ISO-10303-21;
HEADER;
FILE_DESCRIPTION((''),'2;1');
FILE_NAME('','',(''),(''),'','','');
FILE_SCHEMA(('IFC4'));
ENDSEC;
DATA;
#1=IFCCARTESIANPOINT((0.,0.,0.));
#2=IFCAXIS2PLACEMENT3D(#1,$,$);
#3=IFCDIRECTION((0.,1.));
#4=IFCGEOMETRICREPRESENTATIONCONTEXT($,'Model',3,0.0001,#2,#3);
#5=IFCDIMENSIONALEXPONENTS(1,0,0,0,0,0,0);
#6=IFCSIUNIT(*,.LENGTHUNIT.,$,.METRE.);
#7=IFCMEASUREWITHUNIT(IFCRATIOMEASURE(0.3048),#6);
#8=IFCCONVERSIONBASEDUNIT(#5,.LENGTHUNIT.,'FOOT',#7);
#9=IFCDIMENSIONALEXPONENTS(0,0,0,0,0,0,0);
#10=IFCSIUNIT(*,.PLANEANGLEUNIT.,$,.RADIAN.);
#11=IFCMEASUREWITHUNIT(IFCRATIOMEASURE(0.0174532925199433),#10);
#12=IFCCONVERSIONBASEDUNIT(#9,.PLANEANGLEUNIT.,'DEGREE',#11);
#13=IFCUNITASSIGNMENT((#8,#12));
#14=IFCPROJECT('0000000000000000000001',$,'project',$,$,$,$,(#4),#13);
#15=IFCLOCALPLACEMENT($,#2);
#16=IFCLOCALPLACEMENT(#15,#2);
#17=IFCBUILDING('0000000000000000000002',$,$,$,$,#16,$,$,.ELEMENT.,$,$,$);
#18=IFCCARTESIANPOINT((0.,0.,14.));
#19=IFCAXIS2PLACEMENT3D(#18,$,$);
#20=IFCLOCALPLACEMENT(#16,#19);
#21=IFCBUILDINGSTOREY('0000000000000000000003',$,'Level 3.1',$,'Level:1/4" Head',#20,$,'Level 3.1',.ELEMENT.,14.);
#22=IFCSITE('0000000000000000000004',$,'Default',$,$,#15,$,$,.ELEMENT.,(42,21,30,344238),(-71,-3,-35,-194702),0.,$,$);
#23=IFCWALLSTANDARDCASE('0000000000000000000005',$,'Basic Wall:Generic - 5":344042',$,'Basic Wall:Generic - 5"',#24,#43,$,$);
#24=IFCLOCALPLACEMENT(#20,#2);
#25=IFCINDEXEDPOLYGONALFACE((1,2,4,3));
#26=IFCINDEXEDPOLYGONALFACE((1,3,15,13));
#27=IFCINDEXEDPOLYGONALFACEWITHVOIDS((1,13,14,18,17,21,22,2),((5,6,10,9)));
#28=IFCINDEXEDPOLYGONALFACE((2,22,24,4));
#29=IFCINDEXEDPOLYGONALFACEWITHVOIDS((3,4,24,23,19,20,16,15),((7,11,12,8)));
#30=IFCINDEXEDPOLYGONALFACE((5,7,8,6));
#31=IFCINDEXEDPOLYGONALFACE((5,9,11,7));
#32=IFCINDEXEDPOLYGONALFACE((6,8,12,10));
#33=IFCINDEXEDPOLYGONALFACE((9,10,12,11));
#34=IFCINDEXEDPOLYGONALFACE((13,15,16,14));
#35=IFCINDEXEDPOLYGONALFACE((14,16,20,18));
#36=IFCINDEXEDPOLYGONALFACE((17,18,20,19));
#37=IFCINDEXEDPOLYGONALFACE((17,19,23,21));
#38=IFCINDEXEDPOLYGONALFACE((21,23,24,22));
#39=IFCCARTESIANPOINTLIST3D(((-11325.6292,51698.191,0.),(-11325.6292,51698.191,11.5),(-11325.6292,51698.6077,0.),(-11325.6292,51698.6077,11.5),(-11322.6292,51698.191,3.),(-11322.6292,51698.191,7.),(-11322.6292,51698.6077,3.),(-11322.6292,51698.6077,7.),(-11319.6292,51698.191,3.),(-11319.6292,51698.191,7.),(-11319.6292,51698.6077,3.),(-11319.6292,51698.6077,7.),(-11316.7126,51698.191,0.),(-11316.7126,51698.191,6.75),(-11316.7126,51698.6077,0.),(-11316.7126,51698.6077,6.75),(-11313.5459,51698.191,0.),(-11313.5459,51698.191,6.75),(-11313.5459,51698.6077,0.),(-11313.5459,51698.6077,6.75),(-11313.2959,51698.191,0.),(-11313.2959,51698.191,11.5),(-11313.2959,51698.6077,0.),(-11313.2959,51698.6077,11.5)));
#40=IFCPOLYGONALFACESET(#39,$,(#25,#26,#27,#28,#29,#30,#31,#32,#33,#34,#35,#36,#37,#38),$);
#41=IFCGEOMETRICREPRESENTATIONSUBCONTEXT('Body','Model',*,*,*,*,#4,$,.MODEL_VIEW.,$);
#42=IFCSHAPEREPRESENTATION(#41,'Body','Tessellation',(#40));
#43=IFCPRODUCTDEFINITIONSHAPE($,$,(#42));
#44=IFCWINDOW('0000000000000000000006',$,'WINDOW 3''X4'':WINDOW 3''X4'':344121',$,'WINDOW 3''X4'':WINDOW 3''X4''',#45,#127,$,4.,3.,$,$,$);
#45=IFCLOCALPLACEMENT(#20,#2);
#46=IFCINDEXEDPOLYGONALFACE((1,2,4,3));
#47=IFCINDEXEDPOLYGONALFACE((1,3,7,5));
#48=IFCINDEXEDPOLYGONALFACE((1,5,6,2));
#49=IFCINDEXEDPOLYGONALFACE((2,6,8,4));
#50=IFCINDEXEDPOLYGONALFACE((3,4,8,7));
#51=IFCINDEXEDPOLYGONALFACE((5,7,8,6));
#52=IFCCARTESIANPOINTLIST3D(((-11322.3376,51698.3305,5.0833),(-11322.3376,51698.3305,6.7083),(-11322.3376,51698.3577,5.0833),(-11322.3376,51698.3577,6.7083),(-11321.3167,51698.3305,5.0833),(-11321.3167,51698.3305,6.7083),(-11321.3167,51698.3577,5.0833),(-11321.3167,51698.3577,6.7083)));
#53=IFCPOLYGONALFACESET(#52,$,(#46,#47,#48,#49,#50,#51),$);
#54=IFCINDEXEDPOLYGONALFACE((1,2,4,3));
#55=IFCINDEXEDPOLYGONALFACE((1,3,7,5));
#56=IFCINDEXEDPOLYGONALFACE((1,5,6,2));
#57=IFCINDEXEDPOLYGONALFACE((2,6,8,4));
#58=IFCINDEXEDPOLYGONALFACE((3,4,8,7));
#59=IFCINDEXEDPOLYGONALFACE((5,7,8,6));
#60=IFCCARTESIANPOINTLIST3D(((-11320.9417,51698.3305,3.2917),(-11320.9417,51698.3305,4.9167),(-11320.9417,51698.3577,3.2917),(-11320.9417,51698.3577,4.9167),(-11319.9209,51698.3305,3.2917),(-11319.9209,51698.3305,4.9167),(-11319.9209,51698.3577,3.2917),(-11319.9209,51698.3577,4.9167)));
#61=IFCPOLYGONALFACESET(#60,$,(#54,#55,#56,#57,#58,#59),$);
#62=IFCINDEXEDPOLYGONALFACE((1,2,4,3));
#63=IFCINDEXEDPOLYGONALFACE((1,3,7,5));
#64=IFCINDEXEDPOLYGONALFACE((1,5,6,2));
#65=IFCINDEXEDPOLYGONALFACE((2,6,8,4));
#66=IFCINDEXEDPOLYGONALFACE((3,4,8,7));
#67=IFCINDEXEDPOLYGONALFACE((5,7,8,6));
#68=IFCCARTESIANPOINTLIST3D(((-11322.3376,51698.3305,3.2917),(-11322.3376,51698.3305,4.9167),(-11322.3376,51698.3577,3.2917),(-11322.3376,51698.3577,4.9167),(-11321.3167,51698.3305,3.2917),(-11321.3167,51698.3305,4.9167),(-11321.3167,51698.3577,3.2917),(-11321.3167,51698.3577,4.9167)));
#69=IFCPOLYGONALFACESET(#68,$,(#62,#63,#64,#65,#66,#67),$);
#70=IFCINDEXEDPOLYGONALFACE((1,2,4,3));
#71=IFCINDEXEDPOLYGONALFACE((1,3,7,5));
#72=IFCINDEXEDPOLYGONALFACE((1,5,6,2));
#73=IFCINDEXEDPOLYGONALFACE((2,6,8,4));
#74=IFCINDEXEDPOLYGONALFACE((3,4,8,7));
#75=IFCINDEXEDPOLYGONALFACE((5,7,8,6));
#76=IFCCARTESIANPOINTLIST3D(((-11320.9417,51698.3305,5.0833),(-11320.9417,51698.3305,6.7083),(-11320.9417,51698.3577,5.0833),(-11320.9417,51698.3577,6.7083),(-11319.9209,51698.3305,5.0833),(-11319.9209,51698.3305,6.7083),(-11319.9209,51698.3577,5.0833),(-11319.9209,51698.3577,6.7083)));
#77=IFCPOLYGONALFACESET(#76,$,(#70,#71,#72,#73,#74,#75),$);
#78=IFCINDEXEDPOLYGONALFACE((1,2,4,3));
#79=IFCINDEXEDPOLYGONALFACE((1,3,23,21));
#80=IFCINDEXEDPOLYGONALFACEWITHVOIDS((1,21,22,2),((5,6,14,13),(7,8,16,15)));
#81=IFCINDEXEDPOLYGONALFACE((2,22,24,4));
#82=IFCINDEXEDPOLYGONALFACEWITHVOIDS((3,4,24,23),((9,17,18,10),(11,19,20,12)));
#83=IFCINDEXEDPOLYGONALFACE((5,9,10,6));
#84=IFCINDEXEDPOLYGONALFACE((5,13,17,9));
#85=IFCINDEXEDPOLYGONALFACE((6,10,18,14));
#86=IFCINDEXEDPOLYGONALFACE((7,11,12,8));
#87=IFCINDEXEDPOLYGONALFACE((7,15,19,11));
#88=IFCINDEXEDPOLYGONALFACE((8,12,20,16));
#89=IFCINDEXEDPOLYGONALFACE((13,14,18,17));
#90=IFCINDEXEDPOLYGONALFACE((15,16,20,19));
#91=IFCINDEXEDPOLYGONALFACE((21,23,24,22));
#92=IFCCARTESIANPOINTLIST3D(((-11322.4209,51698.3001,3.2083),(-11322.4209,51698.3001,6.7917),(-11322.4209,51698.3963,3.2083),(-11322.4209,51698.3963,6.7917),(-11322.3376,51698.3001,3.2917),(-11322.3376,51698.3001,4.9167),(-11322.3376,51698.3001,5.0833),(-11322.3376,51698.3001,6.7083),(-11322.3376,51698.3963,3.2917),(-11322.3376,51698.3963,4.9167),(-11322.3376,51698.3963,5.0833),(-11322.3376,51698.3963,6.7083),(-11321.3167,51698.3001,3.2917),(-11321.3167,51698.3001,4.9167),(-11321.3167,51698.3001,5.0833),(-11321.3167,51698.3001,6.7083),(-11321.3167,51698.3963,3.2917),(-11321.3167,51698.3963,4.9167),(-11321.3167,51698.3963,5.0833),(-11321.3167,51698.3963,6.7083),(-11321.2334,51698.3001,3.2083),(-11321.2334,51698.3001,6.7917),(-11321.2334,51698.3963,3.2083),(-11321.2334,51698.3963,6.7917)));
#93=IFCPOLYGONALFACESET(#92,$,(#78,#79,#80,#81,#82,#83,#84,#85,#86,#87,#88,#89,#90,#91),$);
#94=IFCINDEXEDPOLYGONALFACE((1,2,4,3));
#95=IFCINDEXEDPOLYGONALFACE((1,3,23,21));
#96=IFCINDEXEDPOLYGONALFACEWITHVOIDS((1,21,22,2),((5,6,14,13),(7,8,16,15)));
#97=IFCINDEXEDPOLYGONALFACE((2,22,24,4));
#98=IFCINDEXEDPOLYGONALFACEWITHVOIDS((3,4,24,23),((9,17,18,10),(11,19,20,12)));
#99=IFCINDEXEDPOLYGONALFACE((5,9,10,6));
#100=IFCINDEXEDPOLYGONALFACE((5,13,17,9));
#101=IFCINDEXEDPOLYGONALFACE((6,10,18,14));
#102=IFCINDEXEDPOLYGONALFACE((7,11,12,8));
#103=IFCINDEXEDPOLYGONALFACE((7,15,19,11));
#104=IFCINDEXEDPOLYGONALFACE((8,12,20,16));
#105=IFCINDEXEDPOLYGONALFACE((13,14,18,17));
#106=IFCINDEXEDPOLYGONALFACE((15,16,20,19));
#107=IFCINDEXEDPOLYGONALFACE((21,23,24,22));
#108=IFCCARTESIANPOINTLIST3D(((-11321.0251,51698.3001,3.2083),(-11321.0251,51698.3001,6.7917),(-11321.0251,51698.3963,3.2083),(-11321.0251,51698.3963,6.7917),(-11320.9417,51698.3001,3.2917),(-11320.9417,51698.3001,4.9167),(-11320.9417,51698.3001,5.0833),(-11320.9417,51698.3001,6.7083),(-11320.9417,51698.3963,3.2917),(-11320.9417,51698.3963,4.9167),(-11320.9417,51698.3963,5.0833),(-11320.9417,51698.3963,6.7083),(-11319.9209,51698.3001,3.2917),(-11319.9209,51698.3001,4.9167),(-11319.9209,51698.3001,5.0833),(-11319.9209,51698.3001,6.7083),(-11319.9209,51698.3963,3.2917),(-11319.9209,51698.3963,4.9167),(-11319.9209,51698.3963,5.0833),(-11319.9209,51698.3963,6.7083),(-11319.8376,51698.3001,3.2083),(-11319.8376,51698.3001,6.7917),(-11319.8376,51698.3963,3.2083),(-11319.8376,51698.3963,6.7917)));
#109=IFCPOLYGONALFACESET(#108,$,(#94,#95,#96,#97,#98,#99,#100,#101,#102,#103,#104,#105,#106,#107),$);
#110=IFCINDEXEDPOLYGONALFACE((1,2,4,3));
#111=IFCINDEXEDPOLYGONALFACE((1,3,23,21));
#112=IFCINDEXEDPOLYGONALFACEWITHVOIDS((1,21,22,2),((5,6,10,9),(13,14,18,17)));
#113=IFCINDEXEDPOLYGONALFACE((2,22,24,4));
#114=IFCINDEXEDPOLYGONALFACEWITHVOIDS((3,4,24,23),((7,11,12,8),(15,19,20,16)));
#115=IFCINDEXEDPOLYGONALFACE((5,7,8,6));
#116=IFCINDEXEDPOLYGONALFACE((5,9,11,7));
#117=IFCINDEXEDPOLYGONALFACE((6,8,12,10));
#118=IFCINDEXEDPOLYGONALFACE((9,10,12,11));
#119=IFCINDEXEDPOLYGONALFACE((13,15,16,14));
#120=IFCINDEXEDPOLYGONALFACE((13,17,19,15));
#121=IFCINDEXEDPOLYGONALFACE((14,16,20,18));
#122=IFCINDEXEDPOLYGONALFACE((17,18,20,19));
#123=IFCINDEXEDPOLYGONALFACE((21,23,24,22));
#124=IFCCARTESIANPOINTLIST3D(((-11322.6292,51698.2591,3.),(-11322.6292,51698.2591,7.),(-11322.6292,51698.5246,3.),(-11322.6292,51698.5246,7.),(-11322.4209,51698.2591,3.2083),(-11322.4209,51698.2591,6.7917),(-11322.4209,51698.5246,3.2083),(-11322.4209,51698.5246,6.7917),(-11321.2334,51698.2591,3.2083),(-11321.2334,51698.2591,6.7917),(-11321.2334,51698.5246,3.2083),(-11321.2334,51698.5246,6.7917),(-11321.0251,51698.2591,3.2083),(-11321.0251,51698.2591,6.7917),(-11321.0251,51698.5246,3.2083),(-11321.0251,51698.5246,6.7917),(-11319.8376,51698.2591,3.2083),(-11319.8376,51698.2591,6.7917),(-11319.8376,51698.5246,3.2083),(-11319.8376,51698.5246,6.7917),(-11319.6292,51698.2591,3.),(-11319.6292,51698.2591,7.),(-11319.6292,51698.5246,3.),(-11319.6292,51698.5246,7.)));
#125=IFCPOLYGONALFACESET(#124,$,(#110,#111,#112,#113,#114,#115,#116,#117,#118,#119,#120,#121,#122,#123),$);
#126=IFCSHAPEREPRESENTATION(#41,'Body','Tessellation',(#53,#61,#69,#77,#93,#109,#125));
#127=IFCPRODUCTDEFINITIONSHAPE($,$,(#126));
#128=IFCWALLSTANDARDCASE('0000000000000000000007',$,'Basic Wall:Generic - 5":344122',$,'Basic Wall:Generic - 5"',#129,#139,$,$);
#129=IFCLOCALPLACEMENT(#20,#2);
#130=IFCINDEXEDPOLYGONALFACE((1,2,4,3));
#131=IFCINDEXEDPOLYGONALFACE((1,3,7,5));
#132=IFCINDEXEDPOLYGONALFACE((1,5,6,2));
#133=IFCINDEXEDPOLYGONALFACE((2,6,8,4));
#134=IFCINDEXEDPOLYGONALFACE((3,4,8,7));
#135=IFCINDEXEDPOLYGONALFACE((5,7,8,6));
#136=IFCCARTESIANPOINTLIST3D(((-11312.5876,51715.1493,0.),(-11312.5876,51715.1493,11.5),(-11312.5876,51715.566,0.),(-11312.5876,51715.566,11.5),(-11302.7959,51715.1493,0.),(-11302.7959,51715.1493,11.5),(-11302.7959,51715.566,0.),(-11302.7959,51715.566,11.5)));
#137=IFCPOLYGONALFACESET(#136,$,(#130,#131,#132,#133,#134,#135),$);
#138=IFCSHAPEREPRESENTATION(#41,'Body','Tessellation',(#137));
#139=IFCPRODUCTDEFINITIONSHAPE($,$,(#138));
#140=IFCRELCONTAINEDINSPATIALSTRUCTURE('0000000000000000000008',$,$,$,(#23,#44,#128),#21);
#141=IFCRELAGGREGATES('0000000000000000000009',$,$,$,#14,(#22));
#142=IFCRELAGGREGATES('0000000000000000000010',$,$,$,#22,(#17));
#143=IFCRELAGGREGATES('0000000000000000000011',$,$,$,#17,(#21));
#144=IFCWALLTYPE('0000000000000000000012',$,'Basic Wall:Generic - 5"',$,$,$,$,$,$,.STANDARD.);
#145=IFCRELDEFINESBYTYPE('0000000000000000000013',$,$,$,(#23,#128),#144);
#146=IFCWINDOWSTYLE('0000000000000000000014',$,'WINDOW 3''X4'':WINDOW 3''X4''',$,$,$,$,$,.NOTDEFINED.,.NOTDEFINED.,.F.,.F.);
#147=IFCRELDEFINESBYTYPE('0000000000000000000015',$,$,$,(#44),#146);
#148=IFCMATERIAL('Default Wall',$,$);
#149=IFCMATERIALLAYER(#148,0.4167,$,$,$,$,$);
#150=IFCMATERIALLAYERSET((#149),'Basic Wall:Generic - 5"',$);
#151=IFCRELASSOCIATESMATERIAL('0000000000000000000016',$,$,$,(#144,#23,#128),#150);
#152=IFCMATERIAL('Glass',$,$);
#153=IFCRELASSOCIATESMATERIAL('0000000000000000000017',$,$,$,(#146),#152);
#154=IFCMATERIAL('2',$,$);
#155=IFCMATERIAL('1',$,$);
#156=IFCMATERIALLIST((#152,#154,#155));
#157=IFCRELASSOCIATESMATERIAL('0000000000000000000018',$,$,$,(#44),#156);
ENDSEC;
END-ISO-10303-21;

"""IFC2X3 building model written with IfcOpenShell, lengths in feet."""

from ifc_helpers import new_model, entity, si_unit, converted_unit, direction, frame, frame_2d, origin, origin_2d_with_axis, place, context, subcontext, project, spatial, polyline, rectangle, outline, extrude, source, transform, mapped, material, material_list, layer, layer_set, layer_usage, type_object, type_shapes, element, fill, save


model = new_model("IFC2X3")

# Units and contexts
model_context = context("Model", 3, precision=0.0001, world=origin(), true_north=direction((0.0, 1.0)))
body_context = subcontext(model_context, "Body", "Model", "MODEL_VIEW")
ifc_project = project(units=[converted_unit("LENGTHUNIT", "FOOT", entity("IfcRatioMeasure", 0.3048), si_unit("LENGTHUNIT", "METRE"), dimensions=[1, 0, 0, 0, 0, 0, 0]), converted_unit("PLANEANGLEUNIT", "DEGREE", entity("IfcRatioMeasure", 0.0174532925199433), si_unit("PLANEANGLEUNIT", "RADIAN"), dimensions=[0, 0, 0, 0, 0, 0, 0])], contexts=[model_context])

# Site, building, storey
site_placement = place(None, origin())
site = spatial("IfcSite", under=ifc_project, at=site_placement, Name="Default", CompositionType="ELEMENT", RefLatitude=(42, 21, 30, 344238), RefLongitude=(-71, -3, -35, -194702), RefElevation=0.0)
building_placement = place(site_placement, origin())
building = spatial("IfcBuilding", under=site, at=building_placement, CompositionType="ELEMENT")
storey_placement = place(building_placement, frame((0.0, 0.0, 14.0)))
storey = spatial("IfcBuildingStorey", under=building, at=storey_placement, Name="Level 3.1", ObjectType="Level:1/4\" Head", LongName="Level 3.1", CompositionType="ELEMENT", Elevation=14.0)

# Shared definitions
ifc_material_1 = material(Name="Default Wall")

# Shared definitions
ifc_layer_1 = layer(ifc_material_1, 0.4167)
ifc_layer_set_1 = layer_set([ifc_layer_1], Name="Basic Wall:Generic - 5\"")
wall_type_1 = type_object("IfcWallType", Name="Basic Wall:Generic - 5\"", PredefinedType="STANDARD", material=ifc_layer_set_1)
ifc_material_2 = material(Name="Glass")
ifc_material_3 = material(Name="2")
ifc_material_4 = material(Name="1")

# Wall, openings, window
window_style_1 = type_object("IfcWindowStyle", Name="WINDOW 3'X4':WINDOW 3'X4'", ConstructionType="NOTDEFINED", OperationType="NOTDEFINED", ParameterTakesPrecedence=False, Sizeable=False, material=ifc_material_2)
shared_shape_1 = source(origin(), body_context, "Body", "SweptSolid", [
    extrude(rectangle(XDim=0.0272, YDim=1.0208, at=origin_2d_with_axis()), frame((2.1979, 0.2636, 2.0833), z_axis=(0.0, 0.0, 1.0), x_axis=(0.0, 1.0, 0.0)), (0.0, 0.0, 1.0), 1.625),
    extrude(rectangle(XDim=0.0272, YDim=1.0208, at=origin_2d_with_axis()), frame((0.8021, 0.2636, 0.2917), z_axis=(0.0, 0.0, 1.0), x_axis=(0.0, 1.0, 0.0)), (0.0, 0.0, 1.0), 1.625),
    extrude(rectangle(XDim=0.0272, YDim=1.0208, at=origin_2d_with_axis()), frame((2.1979, 0.2636, 0.2917), z_axis=(0.0, 0.0, 1.0), x_axis=(0.0, 1.0, 0.0)), (0.0, 0.0, 1.0), 1.625),
    extrude(rectangle(XDim=0.0272, YDim=1.0208, at=origin_2d_with_axis()), frame((0.8021, 0.2636, 2.0833), z_axis=(0.0, 0.0, 1.0), x_axis=(0.0, 1.0, 0.0)), (0.0, 0.0, 1.0), 1.625),
    extrude(outline(polyline([(-0.5938, -1.7917), (0.5938, -1.7917), (0.5938, 1.7917), (-0.5938, 1.7917), (-0.5938, -1.7917)]), holes=[polyline([(-0.5104, -0.0833), (0.5104, -0.0833), (0.5104, -1.7083), (-0.5104, -1.7083), (-0.5104, -0.0833)]), polyline([(-0.5104, 1.7083), (0.5104, 1.7083), (0.5104, 0.0833), (-0.5104, 0.0833), (-0.5104, 1.7083)])]), frame((2.1979, 0.2114, 2.0), z_axis=(0.0, 1.0, 0.0), x_axis=(-1.0, 0.0, 0.0)), (0.0, 0.0, 1.0), 0.0962),
    extrude(outline(polyline([(-1.7917, -0.5937), (1.7917, -0.5937), (1.7917, 0.5937), (-1.7917, 0.5937), (-1.7917, -0.5937)]), holes=[polyline([(0.0833, -0.5104), (0.0833, 0.5104), (1.7083, 0.5104), (1.7083, -0.5104), (0.0833, -0.5104)]), polyline([(-1.7083, -0.5104), (-1.7083, 0.5104), (-0.0833, 0.5104), (-0.0833, -0.5104), (-1.7083, -0.5104)])]), frame((0.8021, 0.2114, 2.0), z_axis=(0.0, 1.0, 0.0), x_axis=(0.0, 0.0, -1.0)), (0.0, 0.0, 1.0), 0.0962),
    extrude(outline(polyline([(-1.5, -2.0), (1.5, -2.0), (1.5, 2.0), (-1.5, 2.0), (-1.5, -2.0)]), holes=[polyline([(-0.1042, 1.7917), (-0.1042, -1.7917), (-1.2917, -1.7917), (-1.2917, 1.7917), (-0.1042, 1.7917)]), polyline([(0.1042, -1.7917), (0.1042, 1.7917), (1.2917, 1.7917), (1.2917, -1.7917), (0.1042, -1.7917)])]), frame((1.5, 0.0831, 2.0), z_axis=(0.0, 1.0, 0.0), x_axis=(1.0, 0.0, 0.0)), (0.0, 0.0, 1.0), 0.2655),
])
type_shapes(window_style_1, [shared_shape_1])
ifc_layer_usage_1 = layer_usage(ifc_layer_set_1, "AXIS2", "NEGATIVE", 0.2083)
wall_1_placement = place(storey_placement, frame((-11325.6292, 51698.3993, 0.0)))
wall_1 = element("IfcWallStandardCase", 1, at=wall_1_placement, inside=storey, type_object=wall_type_1, material=ifc_layer_usage_1, Name="Basic Wall:Generic - 5\":344042", ObjectType="Basic Wall:Generic - 5\"", context=body_context, shape_type="SweptSolid", body=[
    extrude(rectangle(XDim=12.3333, YDim=0.4167, at=frame_2d((6.1667, 0.0), x_axis=(-1.0, 0.0))), origin(), (0.0, 0.0, 1.0), 11.5),
])
opening_1_placement = place(wall_1_placement, frame((8.9167, -0.2083, 0.0)))
element("IfcOpeningElement", 2, at=opening_1_placement, cuts=wall_1, ObjectType="Opening", context=body_context, shape_type="SweptSolid", body=[
    extrude(rectangle(XDim=6.75, YDim=3.1667, at=frame_2d((3.375, 1.5833), x_axis=(1.0, 0.0))), frame((0.0, 0.0, 0.0), z_axis=(0.0, 1.0, 0.0), x_axis=(0.0, 0.0, 1.0)), (0.0, 0.0, 1.0), 0.4167),
])
opening_2_placement = place(wall_1_placement, frame((6.0, 0.2083, 3.0)))
opening_2 = element("IfcOpeningElement", 3, at=opening_2_placement, cuts=wall_1, ObjectType="Opening", context=body_context, shape_type="SweptSolid", body=[
    extrude(rectangle(XDim=4.0, YDim=3.0, at=frame_2d((2.0, 1.5), x_axis=(-1.0, 0.0))), frame((0.0, 0.0, 0.0), z_axis=(0.0, -1.0, 0.0), x_axis=(0.0, 0.0, 1.0)), (0.0, 0.0, 1.0), 0.4167),
])
ifc_material_list_1 = material_list([ifc_material_2, ifc_material_3, ifc_material_4])
window_1_placement = place(opening_2_placement, frame((0.0, 0.0, 0.0), z_axis=(0.0, 0.0, 1.0), x_axis=(-1.0, 0.0, 0.0)))
window_1 = element("IfcWindow", 4, at=window_1_placement, inside=storey, type_object=window_style_1, material=ifc_material_list_1, Name="WINDOW 3'X4':WINDOW 3'X4':344121", ObjectType="WINDOW 3'X4':WINDOW 3'X4'", OverallHeight=4.0, OverallWidth=3.0, context=body_context, shape_type="MappedRepresentation", body=[
    mapped(shared_shape_1, transform((0.0, 0.0, 0.0), scale=1.0)),
])
fill(opening_2, window_1)

# Wall
ifc_layer_usage_2 = layer_usage(ifc_layer_set_1, "AXIS2", "NEGATIVE", 0.2083)
wall_2_placement = place(storey_placement, frame((-11312.5876, 51715.3577, 0.0)))
element("IfcWallStandardCase", 5, at=wall_2_placement, inside=storey, type_object=wall_type_1, material=ifc_layer_usage_2, Name="Basic Wall:Generic - 5\":344122", ObjectType="Basic Wall:Generic - 5\"", context=body_context, shape_type="SweptSolid", body=[
    extrude(rectangle(XDim=9.7917, YDim=0.4167, at=frame_2d((4.8958, 0.0), x_axis=(-1.0, 0.0))), origin(), (0.0, 0.0, 1.0), 11.5),
])

save(model, "model.ifc")
